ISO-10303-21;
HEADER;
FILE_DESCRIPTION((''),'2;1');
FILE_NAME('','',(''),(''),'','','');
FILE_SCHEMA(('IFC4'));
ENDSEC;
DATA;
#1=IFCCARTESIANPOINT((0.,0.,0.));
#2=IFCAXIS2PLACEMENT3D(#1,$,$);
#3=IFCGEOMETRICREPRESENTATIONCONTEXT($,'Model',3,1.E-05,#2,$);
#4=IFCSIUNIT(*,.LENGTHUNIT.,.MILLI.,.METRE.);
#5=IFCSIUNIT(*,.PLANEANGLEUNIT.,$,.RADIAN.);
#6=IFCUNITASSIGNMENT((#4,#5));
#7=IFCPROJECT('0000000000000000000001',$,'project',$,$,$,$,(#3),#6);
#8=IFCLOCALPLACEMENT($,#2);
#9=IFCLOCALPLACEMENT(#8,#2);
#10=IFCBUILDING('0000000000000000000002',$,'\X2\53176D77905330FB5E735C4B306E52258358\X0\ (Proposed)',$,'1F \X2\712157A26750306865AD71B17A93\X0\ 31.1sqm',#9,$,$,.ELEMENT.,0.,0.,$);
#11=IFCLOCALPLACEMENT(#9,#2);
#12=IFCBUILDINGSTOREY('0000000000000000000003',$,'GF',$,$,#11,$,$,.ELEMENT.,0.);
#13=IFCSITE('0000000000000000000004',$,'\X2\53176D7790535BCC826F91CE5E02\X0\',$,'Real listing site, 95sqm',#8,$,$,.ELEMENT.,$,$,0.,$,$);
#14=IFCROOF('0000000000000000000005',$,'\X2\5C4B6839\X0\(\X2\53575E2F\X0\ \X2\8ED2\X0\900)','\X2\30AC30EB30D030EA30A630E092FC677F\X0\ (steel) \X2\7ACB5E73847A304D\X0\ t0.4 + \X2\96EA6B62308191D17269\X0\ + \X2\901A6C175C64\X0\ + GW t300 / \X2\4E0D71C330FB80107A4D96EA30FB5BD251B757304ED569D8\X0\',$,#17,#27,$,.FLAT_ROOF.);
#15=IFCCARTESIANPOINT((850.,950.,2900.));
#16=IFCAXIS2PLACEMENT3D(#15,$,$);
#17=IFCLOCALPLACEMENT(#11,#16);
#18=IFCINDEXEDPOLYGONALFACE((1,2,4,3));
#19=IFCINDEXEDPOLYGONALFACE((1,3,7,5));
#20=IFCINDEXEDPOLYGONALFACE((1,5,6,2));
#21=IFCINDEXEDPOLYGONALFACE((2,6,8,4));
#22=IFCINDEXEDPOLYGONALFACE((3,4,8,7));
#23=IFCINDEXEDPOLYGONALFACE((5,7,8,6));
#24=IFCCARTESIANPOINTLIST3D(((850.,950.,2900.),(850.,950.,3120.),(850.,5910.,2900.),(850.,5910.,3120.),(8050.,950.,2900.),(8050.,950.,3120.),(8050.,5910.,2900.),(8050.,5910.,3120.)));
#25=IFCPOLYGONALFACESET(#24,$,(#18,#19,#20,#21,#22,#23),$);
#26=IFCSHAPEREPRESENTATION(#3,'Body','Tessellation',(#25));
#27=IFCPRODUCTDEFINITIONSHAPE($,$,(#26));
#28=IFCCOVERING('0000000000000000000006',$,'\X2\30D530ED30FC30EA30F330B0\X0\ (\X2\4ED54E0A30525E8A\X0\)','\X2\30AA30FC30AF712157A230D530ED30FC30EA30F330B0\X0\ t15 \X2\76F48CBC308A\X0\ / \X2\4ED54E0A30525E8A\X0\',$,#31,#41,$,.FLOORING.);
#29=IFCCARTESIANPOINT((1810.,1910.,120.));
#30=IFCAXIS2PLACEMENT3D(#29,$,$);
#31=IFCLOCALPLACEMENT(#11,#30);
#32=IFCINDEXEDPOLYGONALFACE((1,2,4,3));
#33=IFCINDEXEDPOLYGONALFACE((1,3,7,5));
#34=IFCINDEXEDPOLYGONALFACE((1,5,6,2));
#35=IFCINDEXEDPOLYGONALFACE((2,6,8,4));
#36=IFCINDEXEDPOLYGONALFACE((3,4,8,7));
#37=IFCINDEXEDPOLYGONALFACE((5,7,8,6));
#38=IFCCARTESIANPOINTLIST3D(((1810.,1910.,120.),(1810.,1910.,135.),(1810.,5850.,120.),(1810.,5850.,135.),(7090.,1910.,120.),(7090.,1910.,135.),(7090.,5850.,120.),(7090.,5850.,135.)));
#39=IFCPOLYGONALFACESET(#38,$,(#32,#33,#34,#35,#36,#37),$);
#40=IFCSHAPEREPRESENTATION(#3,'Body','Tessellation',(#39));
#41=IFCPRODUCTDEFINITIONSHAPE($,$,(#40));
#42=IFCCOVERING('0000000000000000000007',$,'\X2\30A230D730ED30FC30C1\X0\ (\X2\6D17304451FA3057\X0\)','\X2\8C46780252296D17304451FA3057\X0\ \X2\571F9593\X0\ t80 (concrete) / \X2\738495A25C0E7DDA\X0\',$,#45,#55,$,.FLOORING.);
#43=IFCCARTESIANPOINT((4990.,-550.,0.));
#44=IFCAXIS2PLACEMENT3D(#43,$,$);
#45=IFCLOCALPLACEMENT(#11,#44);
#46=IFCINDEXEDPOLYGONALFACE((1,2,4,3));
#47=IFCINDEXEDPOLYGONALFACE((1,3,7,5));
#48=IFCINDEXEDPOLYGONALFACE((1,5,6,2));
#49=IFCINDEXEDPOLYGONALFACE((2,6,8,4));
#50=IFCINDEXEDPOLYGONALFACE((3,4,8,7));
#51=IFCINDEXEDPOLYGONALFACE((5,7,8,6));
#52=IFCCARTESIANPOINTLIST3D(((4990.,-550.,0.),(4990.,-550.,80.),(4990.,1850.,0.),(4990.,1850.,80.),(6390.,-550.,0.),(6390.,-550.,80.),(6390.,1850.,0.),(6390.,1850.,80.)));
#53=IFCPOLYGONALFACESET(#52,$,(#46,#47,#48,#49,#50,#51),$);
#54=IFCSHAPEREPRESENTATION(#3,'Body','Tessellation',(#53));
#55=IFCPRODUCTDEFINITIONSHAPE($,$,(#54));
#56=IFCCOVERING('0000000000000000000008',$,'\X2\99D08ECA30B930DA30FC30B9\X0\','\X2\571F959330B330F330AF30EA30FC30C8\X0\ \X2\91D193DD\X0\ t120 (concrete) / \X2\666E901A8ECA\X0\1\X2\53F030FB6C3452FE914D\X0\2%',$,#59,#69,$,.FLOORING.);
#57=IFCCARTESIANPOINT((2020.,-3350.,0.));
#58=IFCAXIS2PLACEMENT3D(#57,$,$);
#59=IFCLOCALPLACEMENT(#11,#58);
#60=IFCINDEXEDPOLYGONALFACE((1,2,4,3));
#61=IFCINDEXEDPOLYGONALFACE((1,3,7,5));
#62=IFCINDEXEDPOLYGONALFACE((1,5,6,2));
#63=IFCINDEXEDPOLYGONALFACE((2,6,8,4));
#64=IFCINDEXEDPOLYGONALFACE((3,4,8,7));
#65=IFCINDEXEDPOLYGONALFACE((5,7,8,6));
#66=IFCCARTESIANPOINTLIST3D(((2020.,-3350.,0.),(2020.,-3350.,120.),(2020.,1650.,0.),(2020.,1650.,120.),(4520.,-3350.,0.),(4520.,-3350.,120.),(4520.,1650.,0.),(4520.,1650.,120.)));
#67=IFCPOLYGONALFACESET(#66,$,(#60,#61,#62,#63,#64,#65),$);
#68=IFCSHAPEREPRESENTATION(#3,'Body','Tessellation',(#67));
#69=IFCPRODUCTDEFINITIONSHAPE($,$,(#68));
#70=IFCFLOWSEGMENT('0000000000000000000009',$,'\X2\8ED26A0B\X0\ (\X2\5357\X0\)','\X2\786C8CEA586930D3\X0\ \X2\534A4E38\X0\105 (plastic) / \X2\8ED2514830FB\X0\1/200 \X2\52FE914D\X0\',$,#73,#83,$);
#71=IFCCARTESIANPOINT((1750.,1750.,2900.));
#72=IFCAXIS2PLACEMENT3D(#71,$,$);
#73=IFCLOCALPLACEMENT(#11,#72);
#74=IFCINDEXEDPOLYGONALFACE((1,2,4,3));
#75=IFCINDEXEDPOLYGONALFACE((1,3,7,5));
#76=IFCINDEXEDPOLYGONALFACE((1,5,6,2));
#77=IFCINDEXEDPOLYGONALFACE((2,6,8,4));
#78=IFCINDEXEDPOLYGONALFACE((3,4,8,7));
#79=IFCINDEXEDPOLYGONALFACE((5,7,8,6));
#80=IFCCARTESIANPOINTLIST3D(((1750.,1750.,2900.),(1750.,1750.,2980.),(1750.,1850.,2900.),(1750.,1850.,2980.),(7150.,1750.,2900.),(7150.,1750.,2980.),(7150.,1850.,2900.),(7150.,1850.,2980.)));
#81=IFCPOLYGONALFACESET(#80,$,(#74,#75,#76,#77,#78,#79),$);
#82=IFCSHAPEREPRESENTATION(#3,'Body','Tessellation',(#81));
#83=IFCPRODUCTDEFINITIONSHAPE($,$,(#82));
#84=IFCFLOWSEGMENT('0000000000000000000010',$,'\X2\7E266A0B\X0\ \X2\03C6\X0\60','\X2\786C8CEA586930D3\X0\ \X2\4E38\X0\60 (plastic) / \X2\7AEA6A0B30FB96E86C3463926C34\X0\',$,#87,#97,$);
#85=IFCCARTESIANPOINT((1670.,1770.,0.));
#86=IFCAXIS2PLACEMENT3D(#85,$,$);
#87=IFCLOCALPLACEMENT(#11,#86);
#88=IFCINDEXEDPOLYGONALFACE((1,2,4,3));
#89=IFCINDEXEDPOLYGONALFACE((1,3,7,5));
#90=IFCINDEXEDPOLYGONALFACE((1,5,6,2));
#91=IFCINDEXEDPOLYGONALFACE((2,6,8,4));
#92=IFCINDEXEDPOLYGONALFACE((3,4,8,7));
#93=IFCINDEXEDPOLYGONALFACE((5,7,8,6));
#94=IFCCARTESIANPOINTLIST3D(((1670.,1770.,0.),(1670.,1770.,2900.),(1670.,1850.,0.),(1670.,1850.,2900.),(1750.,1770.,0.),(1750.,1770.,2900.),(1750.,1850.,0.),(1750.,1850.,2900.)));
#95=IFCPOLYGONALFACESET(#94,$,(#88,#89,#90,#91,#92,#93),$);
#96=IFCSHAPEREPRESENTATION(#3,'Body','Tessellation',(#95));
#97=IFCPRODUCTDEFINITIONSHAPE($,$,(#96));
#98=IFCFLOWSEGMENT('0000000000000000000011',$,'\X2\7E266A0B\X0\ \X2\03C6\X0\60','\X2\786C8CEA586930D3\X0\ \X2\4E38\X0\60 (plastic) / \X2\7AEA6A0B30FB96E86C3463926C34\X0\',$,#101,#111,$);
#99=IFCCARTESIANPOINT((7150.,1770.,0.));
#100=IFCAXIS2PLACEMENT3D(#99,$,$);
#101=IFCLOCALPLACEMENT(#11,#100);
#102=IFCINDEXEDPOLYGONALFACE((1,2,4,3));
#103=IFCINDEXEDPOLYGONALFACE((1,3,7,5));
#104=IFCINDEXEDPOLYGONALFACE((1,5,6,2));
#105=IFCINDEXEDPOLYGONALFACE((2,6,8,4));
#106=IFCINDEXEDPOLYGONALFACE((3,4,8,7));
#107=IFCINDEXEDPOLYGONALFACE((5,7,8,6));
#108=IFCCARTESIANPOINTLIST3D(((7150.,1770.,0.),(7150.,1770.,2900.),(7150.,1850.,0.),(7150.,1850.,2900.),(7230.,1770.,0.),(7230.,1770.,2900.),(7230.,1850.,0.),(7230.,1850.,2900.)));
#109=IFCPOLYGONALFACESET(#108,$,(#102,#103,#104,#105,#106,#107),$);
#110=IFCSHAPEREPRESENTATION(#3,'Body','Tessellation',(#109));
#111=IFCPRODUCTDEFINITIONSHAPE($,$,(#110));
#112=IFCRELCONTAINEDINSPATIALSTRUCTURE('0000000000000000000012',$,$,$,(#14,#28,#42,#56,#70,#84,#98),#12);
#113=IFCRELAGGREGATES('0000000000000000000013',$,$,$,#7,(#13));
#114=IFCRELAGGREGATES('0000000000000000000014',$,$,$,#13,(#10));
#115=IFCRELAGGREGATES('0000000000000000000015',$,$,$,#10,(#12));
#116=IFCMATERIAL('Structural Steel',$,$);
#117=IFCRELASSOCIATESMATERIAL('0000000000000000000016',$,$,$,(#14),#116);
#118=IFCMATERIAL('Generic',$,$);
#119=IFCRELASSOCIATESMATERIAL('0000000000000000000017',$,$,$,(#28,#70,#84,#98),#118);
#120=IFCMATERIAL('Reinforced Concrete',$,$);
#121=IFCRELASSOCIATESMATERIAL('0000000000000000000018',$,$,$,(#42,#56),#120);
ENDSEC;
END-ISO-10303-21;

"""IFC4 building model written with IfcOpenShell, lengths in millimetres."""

from ifc_helpers import new_model, si_unit, frame, frame_2d, origin, place, context, project, spatial, rectangle, extrude, material, element, save


model = new_model("IFC4")

# Units and contexts
model_context = context("Model", 3, precision=1e-05, world=origin())
ifc_project = project(units=[si_unit("LENGTHUNIT", "METRE", prefix="MILLI"), si_unit("PLANEANGLEUNIT", "RADIAN")], contexts=[model_context])

# Site, building, storey
site_placement = place(None, origin())
site = spatial("IfcSite", under=ifc_project, at=site_placement, Name="北海道富良野市", ObjectType="Real listing site, 95sqm", CompositionType="ELEMENT", RefElevation=0.0)
building_placement = place(site_placement, origin())
building = spatial("IfcBuilding", under=site, at=building_placement, Name="北海道・平屋の別荘 (Proposed)", ObjectType="1F 無垢材と断熱窓 31.1sqm", CompositionType="ELEMENT", ElevationOfRefHeight=0.0, ElevationOfTerrain=0.0)
storey_placement = place(building_placement, origin())
storey = spatial("IfcBuildingStorey", under=building, at=storey_placement, Name="GF", CompositionType="ELEMENT", Elevation=0.0)

# Shared definitions
ifc_material_1 = material(Name="Reinforced Concrete")

# Roof
ifc_material_2 = material(Name="Structural Steel")
roof_placement = place(storey_placement, frame((850.0, 950.0, 2900.0)))
element("IfcRoof", 1, at=roof_placement, inside=storey, material=ifc_material_2, Name="屋根(南帯 軒900)", Description="ガルバリウム鋼板 (steel) 立平葺き t0.4 + 雪止め金物 + 通気層 + GW t300 / 不燃・耐積雪・寒冷地仕様", PredefinedType="FLAT_ROOF", context=model_context, shape_type="SweptSolid", body=[
    extrude(rectangle(XDim=7200.0, YDim=4960.0, at=frame_2d((3600.0, 2480.0))), frame((850.0, 950.0, 2900.0)), (0.0, 0.0, 1.0), 220.0),
])

# Coverings
ifc_material_3 = material(Name="Generic")
covering_1_placement = place(storey_placement, frame((1810.0, 1910.0, 120.0)))
element("IfcCovering", 2, at=covering_1_placement, inside=storey, material=ifc_material_3, Name="フローリング (仕上げ床)", Description="オーク無垢フローリング t15 直貼り / 仕上げ床", PredefinedType="FLOORING", context=model_context, shape_type="SweptSolid", body=[
    extrude(rectangle(XDim=5280.0, YDim=3940.0, at=frame_2d((2640.0, 1970.0))), frame((1810.0, 1910.0, 120.0)), (0.0, 0.0, 1.0), 15.0),
])
covering_2_placement = place(storey_placement, frame((4990.0, -550.0, 0.0)))
element("IfcCovering", 3, at=covering_2_placement, inside=storey, material=ifc_material_1, Name="アプローチ (洗い出し)", Description="豆砂利洗い出し 土間 t80 (concrete) / 玄関導線", PredefinedType="FLOORING", context=model_context, shape_type="SweptSolid", body=[
    extrude(rectangle(XDim=1400.0, YDim=2400.0, at=frame_2d((700.0, 1200.0))), frame((4990.0, -550.0, 0.0)), (0.0, 0.0, 1.0), 80.0),
])
covering_3_placement = place(storey_placement, frame((2020.0, -3350.0, 0.0)))
element("IfcCovering", 4, at=covering_3_placement, inside=storey, material=ifc_material_1, Name="駐車スペース", Description="土間コンクリート 金鏝 t120 (concrete) / 普通車1台・水勾配2%", PredefinedType="FLOORING", context=model_context, shape_type="SweptSolid", body=[
    extrude(rectangle(XDim=2500.0, YDim=5000.0, at=frame_2d((1250.0, 2500.0))), frame((2020.0, -3350.0, 0.0)), (0.0, 0.0, 1.0), 120.0),
])

# Flow segments
flow_segment_1_placement = place(storey_placement, frame((1750.0, 1750.0, 2900.0)))
element("IfcFlowSegment", 5, at=flow_segment_1_placement, inside=storey, material=ifc_material_3, Name="軒樋 (南)", Description="硬質塩ビ 半丸105 (plastic) / 軒先・1/200 勾配", context=model_context, shape_type="SweptSolid", body=[
    extrude(rectangle(XDim=5400.0, YDim=100.0, at=frame_2d((2700.0, 50.0))), frame((1750.0, 1750.0, 2900.0)), (0.0, 0.0, 1.0), 80.0),
])
flow_segment_2_placement = place(storey_placement, frame((1670.0, 1770.0, 0.0)))
element("IfcFlowSegment", 6, at=flow_segment_2_placement, inside=storey, material=ifc_material_3, Name="縦樋 φ60", Description="硬質塩ビ 丸60 (plastic) / 竪樋・雨水排水", context=model_context, shape_type="SweptSolid", body=[
    extrude(rectangle(XDim=80.0, YDim=80.0, at=frame_2d((40.0, 40.0))), frame((1670.0, 1770.0, 0.0)), (0.0, 0.0, 1.0), 2900.0),
])
flow_segment_3_placement = place(storey_placement, frame((7150.0, 1770.0, 0.0)))
element("IfcFlowSegment", 7, at=flow_segment_3_placement, inside=storey, material=ifc_material_3, Name="縦樋 φ60", Description="硬質塩ビ 丸60 (plastic) / 竪樋・雨水排水", context=model_context, shape_type="SweptSolid", body=[
    extrude(rectangle(XDim=80.0, YDim=80.0, at=frame_2d((40.0, 40.0))), frame((7150.0, 1770.0, 0.0)), (0.0, 0.0, 1.0), 2900.0),
])

save(model, "model.ifc")
